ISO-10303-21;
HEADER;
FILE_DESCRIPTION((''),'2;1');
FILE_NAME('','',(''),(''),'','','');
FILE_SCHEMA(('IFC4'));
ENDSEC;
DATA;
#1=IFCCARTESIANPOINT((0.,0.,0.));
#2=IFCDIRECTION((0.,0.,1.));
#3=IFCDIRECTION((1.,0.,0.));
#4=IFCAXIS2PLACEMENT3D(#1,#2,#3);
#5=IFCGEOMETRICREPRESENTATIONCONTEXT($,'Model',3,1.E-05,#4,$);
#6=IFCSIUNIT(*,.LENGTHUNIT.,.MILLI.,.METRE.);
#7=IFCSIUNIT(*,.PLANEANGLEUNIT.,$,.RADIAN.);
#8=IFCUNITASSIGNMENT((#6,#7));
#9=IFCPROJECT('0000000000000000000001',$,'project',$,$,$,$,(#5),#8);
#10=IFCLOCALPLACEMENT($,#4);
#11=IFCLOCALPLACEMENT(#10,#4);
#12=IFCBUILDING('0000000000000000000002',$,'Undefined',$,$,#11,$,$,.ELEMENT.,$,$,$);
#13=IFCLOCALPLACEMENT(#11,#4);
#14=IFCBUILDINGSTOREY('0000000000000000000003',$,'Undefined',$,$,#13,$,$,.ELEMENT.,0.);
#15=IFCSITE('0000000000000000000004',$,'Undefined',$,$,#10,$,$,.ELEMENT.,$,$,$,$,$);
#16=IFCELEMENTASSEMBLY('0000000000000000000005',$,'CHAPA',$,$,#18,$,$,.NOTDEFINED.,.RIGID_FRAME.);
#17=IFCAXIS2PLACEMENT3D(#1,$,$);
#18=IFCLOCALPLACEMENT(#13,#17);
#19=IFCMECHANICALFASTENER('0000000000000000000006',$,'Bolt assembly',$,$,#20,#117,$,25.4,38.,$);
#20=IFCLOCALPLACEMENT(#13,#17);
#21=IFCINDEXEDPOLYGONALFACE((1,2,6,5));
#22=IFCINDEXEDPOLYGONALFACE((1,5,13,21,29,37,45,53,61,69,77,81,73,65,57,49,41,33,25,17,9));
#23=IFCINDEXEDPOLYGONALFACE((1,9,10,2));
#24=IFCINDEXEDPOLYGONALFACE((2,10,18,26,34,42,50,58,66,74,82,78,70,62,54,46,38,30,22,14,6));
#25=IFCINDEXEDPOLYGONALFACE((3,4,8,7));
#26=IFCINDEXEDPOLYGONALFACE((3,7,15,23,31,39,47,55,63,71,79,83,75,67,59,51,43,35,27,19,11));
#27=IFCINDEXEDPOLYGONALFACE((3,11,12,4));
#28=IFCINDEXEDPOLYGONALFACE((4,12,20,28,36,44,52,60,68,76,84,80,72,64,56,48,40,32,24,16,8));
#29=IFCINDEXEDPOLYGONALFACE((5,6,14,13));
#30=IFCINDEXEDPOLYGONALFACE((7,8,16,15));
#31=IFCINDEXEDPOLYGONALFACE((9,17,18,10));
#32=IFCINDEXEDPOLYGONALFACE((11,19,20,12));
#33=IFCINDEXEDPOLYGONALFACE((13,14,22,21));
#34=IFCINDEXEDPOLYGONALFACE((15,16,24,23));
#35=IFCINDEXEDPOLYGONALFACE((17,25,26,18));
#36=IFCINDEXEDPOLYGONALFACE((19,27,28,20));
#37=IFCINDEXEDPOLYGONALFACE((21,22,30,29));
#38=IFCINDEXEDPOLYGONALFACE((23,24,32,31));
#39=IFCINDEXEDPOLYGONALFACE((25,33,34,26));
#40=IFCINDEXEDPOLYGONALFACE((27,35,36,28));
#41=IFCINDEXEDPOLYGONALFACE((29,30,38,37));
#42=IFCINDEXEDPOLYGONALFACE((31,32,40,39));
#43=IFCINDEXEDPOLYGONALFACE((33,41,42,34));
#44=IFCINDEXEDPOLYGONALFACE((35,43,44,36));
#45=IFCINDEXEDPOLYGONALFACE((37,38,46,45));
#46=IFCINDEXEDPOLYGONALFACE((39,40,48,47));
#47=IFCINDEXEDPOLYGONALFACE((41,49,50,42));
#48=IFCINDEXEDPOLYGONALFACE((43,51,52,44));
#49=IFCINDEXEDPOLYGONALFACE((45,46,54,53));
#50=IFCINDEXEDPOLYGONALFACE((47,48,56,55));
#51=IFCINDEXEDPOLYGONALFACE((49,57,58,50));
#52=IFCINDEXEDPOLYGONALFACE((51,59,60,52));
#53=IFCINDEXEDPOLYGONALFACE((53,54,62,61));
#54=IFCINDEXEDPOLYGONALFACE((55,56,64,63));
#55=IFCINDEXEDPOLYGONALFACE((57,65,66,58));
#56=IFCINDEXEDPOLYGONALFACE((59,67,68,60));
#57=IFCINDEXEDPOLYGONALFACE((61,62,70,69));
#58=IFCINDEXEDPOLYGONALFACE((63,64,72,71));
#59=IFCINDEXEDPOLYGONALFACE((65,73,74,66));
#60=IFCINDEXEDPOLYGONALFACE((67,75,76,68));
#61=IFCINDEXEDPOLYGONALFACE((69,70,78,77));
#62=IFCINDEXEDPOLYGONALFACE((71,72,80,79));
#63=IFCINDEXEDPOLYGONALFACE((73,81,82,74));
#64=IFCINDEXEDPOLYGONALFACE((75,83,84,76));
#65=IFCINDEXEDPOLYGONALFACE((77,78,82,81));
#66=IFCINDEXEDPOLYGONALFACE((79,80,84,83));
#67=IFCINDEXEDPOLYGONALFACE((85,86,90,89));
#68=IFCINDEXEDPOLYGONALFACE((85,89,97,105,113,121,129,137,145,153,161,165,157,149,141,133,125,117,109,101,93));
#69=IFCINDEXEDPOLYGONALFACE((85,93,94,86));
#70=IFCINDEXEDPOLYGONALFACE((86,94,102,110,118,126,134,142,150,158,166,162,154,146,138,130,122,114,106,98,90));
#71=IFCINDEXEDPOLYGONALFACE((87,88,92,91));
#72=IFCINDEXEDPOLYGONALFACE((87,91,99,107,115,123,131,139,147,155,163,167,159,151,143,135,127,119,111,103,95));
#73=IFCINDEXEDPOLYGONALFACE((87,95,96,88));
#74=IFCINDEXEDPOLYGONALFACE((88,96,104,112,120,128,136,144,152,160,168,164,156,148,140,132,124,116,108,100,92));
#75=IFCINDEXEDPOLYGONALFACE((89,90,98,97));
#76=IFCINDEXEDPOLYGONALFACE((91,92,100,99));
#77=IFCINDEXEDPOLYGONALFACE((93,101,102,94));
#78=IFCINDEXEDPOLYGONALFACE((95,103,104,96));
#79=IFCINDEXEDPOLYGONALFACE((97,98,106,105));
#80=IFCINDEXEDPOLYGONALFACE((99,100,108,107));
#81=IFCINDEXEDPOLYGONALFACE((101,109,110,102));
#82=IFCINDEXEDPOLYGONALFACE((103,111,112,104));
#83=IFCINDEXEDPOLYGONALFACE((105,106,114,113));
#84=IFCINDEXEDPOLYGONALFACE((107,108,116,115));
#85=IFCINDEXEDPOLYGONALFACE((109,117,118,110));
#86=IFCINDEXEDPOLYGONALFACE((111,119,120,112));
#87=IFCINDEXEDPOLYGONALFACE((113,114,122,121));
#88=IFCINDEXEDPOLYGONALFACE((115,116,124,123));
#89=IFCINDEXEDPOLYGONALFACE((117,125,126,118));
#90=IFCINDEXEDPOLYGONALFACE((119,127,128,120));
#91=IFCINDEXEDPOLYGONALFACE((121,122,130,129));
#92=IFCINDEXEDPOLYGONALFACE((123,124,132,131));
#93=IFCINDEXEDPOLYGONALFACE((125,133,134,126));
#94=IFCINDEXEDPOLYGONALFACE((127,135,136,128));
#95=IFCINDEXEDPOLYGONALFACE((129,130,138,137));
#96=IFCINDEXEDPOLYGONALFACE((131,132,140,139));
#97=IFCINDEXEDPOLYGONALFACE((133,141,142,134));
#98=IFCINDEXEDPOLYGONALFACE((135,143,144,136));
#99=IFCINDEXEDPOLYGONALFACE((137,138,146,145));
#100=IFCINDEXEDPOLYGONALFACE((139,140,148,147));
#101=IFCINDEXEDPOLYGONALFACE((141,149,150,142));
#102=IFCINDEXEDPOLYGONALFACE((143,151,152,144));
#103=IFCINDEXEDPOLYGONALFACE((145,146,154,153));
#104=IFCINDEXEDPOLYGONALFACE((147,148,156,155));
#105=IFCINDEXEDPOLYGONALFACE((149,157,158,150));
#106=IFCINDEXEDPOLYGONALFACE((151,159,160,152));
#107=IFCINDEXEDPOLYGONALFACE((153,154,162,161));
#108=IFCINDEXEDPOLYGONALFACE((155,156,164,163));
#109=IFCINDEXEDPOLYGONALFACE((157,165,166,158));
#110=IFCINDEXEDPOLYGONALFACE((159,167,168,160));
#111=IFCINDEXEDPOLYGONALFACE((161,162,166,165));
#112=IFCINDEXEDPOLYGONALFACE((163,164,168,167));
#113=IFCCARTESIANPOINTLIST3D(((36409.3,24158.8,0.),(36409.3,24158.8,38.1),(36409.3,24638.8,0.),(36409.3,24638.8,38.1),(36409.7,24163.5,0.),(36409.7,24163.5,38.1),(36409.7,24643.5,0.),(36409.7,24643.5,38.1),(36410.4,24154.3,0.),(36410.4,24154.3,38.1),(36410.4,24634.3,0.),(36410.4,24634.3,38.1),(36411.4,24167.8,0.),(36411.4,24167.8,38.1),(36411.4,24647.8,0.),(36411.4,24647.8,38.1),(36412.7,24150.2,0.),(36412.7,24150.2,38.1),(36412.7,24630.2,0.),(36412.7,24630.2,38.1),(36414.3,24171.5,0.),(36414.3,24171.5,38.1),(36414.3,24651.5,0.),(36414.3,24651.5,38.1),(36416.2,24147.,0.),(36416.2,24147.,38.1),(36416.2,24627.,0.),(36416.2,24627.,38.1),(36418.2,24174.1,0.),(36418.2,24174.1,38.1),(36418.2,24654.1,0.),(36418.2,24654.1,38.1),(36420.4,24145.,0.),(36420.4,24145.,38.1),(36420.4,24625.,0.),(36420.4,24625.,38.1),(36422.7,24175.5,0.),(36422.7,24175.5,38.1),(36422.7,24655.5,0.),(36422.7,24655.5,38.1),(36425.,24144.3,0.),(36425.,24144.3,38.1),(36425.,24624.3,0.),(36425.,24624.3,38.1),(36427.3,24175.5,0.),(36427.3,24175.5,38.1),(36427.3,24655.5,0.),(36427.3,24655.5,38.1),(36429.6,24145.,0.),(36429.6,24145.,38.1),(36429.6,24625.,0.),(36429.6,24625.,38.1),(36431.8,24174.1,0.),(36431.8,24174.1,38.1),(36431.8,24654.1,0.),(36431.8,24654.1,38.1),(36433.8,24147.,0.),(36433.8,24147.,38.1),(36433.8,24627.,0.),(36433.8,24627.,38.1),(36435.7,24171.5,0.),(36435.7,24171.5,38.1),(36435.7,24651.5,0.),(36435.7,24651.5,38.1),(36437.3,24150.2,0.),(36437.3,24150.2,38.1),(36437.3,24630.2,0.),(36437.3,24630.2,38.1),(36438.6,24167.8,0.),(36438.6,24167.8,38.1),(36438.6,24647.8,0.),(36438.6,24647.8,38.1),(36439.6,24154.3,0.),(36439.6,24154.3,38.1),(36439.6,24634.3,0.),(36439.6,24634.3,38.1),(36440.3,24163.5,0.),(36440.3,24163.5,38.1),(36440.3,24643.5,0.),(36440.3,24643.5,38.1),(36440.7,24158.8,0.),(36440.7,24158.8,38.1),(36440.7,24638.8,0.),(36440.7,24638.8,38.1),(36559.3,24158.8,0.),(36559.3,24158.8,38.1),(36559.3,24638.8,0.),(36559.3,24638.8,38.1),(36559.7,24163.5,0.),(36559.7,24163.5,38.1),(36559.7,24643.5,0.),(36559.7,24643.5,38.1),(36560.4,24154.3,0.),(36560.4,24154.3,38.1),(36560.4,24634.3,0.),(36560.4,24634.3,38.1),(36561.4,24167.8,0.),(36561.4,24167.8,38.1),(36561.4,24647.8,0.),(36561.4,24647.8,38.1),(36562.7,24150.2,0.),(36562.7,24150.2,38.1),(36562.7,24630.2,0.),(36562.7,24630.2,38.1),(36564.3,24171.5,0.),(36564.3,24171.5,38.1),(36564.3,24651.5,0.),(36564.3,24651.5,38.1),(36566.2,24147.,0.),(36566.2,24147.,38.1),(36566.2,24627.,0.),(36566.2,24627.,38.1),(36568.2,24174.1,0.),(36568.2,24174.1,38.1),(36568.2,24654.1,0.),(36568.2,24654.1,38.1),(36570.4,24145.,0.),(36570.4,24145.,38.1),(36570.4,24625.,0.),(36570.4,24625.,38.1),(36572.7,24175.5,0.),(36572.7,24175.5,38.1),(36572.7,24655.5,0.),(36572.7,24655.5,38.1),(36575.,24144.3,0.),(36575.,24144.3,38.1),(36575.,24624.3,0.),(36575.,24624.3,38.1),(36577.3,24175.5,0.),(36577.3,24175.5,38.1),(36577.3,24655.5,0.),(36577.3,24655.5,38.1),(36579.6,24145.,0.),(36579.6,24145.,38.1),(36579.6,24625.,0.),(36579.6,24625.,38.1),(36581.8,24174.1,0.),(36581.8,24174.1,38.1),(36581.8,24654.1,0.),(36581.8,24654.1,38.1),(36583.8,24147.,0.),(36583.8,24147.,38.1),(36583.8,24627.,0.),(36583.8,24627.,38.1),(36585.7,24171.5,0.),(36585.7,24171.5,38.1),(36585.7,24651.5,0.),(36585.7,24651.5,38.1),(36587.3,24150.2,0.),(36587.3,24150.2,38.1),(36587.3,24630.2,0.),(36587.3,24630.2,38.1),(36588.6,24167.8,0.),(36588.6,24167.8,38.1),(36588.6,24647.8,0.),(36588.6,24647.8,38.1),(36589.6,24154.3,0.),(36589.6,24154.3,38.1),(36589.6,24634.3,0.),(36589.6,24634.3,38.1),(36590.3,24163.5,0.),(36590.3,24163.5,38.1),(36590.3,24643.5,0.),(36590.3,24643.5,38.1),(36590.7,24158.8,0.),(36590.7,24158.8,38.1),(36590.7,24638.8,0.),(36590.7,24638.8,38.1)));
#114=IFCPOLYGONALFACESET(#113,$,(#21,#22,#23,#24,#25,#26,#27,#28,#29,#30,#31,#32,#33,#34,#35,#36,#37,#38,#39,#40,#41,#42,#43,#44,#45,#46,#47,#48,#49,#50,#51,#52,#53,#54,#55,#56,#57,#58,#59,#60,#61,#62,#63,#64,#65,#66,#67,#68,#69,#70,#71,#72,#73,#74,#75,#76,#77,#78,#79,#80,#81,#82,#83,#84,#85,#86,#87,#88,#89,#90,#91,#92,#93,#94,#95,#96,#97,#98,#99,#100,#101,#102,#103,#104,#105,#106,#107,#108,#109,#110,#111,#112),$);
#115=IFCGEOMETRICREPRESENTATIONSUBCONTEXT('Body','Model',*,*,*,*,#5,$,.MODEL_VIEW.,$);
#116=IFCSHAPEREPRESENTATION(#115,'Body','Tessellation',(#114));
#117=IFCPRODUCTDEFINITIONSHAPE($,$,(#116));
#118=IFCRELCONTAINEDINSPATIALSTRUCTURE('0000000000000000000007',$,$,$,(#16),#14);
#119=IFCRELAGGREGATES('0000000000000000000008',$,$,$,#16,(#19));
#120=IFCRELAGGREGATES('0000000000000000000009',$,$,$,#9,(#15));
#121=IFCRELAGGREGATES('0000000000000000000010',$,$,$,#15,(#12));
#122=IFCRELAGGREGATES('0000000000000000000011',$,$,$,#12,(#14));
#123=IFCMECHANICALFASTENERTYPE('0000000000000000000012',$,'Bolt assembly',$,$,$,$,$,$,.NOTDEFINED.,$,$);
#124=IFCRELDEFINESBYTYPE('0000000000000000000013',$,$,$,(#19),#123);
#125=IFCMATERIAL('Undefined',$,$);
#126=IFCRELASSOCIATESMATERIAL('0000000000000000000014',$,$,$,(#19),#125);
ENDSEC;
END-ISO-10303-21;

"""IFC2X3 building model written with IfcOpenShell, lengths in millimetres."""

from ifc_helpers import new_model, si_unit, frame, origin_with_axes, origin_2d_with_axis, place, context, subcontext, project, spatial, circle, extrude, source, transform, mapped, material, type_object, element, aggregate, save


model = new_model("IFC2X3")

# Units and contexts
model_context = context("Model", 3, precision=1e-05, world=origin_with_axes())
body_context = subcontext(model_context, "Body", "Model", "MODEL_VIEW")
ifc_project = project(units=[si_unit("LENGTHUNIT", "METRE", prefix="MILLI"), si_unit("PLANEANGLEUNIT", "RADIAN")], contexts=[model_context])

# Site, building, storey
site_placement = place(None, origin_with_axes())
site = spatial("IfcSite", under=ifc_project, at=site_placement, Name="Undefined", CompositionType="ELEMENT")
building_placement = place(site_placement, origin_with_axes())
building = spatial("IfcBuilding", under=site, at=building_placement, Name="Undefined", CompositionType="ELEMENT")
storey_placement = place(building_placement, origin_with_axes())
storey = spatial("IfcBuildingStorey", under=building, at=storey_placement, Name="Undefined", CompositionType="ELEMENT", Elevation=0.0)

# Element assembly
assembly_1_placement = place(storey_placement, origin_with_axes())
assembly_1 = element("IfcElementAssembly", 1, at=assembly_1_placement, inside=storey, Name="CHAPA", AssemblyPlace="NOTDEFINED", PredefinedType="RIGID_FRAME")

# Shared definitions
ifc_material_1 = material(Name="Undefined")
mechanical_fastener_type = type_object("IfcMechanicalFastenerType", Name="Bolt assembly")

# Mechanical fastener
shared_shape_1 = source(origin_with_axes(), body_context, "Body", "SweptSolid", [
    extrude(circle(Radius=15.7, at=origin_2d_with_axis()), frame((0.0, -38.0, 0.0), z_axis=(0.0, 1.0, 0.0), x_axis=(1.0, 0.0, 0.0)), (0.0, 0.0, 1.0), 38.1),
])
mechanical_fastener_1_placement = place(assembly_1_placement, frame((36500.0, 24640.0, 38.0), z_axis=(-1.0, 0.0, 0.0), x_axis=(0.0, -1.0, 0.0)))
mechanical_fastener_1 = element("IfcMechanicalFastener", 2, at=mechanical_fastener_1_placement, type_object=mechanical_fastener_type, material=ifc_material_1, Name="Bolt assembly", NominalDiameter=25.4, NominalLength=38.0, context=body_context, shape_type="MappedRepresentation", body=[
    mapped(shared_shape_1, transform((0.0, 0.0, -75.0))),
    mapped(shared_shape_1, transform((0.0, 0.0, 75.0))),
    mapped(shared_shape_1, transform((480.0, 0.0, -75.0))),
    mapped(shared_shape_1, transform((480.0, 0.0, 75.0))),
])
aggregate(assembly_1, [mechanical_fastener_1])

save(model, "model.ifc")
